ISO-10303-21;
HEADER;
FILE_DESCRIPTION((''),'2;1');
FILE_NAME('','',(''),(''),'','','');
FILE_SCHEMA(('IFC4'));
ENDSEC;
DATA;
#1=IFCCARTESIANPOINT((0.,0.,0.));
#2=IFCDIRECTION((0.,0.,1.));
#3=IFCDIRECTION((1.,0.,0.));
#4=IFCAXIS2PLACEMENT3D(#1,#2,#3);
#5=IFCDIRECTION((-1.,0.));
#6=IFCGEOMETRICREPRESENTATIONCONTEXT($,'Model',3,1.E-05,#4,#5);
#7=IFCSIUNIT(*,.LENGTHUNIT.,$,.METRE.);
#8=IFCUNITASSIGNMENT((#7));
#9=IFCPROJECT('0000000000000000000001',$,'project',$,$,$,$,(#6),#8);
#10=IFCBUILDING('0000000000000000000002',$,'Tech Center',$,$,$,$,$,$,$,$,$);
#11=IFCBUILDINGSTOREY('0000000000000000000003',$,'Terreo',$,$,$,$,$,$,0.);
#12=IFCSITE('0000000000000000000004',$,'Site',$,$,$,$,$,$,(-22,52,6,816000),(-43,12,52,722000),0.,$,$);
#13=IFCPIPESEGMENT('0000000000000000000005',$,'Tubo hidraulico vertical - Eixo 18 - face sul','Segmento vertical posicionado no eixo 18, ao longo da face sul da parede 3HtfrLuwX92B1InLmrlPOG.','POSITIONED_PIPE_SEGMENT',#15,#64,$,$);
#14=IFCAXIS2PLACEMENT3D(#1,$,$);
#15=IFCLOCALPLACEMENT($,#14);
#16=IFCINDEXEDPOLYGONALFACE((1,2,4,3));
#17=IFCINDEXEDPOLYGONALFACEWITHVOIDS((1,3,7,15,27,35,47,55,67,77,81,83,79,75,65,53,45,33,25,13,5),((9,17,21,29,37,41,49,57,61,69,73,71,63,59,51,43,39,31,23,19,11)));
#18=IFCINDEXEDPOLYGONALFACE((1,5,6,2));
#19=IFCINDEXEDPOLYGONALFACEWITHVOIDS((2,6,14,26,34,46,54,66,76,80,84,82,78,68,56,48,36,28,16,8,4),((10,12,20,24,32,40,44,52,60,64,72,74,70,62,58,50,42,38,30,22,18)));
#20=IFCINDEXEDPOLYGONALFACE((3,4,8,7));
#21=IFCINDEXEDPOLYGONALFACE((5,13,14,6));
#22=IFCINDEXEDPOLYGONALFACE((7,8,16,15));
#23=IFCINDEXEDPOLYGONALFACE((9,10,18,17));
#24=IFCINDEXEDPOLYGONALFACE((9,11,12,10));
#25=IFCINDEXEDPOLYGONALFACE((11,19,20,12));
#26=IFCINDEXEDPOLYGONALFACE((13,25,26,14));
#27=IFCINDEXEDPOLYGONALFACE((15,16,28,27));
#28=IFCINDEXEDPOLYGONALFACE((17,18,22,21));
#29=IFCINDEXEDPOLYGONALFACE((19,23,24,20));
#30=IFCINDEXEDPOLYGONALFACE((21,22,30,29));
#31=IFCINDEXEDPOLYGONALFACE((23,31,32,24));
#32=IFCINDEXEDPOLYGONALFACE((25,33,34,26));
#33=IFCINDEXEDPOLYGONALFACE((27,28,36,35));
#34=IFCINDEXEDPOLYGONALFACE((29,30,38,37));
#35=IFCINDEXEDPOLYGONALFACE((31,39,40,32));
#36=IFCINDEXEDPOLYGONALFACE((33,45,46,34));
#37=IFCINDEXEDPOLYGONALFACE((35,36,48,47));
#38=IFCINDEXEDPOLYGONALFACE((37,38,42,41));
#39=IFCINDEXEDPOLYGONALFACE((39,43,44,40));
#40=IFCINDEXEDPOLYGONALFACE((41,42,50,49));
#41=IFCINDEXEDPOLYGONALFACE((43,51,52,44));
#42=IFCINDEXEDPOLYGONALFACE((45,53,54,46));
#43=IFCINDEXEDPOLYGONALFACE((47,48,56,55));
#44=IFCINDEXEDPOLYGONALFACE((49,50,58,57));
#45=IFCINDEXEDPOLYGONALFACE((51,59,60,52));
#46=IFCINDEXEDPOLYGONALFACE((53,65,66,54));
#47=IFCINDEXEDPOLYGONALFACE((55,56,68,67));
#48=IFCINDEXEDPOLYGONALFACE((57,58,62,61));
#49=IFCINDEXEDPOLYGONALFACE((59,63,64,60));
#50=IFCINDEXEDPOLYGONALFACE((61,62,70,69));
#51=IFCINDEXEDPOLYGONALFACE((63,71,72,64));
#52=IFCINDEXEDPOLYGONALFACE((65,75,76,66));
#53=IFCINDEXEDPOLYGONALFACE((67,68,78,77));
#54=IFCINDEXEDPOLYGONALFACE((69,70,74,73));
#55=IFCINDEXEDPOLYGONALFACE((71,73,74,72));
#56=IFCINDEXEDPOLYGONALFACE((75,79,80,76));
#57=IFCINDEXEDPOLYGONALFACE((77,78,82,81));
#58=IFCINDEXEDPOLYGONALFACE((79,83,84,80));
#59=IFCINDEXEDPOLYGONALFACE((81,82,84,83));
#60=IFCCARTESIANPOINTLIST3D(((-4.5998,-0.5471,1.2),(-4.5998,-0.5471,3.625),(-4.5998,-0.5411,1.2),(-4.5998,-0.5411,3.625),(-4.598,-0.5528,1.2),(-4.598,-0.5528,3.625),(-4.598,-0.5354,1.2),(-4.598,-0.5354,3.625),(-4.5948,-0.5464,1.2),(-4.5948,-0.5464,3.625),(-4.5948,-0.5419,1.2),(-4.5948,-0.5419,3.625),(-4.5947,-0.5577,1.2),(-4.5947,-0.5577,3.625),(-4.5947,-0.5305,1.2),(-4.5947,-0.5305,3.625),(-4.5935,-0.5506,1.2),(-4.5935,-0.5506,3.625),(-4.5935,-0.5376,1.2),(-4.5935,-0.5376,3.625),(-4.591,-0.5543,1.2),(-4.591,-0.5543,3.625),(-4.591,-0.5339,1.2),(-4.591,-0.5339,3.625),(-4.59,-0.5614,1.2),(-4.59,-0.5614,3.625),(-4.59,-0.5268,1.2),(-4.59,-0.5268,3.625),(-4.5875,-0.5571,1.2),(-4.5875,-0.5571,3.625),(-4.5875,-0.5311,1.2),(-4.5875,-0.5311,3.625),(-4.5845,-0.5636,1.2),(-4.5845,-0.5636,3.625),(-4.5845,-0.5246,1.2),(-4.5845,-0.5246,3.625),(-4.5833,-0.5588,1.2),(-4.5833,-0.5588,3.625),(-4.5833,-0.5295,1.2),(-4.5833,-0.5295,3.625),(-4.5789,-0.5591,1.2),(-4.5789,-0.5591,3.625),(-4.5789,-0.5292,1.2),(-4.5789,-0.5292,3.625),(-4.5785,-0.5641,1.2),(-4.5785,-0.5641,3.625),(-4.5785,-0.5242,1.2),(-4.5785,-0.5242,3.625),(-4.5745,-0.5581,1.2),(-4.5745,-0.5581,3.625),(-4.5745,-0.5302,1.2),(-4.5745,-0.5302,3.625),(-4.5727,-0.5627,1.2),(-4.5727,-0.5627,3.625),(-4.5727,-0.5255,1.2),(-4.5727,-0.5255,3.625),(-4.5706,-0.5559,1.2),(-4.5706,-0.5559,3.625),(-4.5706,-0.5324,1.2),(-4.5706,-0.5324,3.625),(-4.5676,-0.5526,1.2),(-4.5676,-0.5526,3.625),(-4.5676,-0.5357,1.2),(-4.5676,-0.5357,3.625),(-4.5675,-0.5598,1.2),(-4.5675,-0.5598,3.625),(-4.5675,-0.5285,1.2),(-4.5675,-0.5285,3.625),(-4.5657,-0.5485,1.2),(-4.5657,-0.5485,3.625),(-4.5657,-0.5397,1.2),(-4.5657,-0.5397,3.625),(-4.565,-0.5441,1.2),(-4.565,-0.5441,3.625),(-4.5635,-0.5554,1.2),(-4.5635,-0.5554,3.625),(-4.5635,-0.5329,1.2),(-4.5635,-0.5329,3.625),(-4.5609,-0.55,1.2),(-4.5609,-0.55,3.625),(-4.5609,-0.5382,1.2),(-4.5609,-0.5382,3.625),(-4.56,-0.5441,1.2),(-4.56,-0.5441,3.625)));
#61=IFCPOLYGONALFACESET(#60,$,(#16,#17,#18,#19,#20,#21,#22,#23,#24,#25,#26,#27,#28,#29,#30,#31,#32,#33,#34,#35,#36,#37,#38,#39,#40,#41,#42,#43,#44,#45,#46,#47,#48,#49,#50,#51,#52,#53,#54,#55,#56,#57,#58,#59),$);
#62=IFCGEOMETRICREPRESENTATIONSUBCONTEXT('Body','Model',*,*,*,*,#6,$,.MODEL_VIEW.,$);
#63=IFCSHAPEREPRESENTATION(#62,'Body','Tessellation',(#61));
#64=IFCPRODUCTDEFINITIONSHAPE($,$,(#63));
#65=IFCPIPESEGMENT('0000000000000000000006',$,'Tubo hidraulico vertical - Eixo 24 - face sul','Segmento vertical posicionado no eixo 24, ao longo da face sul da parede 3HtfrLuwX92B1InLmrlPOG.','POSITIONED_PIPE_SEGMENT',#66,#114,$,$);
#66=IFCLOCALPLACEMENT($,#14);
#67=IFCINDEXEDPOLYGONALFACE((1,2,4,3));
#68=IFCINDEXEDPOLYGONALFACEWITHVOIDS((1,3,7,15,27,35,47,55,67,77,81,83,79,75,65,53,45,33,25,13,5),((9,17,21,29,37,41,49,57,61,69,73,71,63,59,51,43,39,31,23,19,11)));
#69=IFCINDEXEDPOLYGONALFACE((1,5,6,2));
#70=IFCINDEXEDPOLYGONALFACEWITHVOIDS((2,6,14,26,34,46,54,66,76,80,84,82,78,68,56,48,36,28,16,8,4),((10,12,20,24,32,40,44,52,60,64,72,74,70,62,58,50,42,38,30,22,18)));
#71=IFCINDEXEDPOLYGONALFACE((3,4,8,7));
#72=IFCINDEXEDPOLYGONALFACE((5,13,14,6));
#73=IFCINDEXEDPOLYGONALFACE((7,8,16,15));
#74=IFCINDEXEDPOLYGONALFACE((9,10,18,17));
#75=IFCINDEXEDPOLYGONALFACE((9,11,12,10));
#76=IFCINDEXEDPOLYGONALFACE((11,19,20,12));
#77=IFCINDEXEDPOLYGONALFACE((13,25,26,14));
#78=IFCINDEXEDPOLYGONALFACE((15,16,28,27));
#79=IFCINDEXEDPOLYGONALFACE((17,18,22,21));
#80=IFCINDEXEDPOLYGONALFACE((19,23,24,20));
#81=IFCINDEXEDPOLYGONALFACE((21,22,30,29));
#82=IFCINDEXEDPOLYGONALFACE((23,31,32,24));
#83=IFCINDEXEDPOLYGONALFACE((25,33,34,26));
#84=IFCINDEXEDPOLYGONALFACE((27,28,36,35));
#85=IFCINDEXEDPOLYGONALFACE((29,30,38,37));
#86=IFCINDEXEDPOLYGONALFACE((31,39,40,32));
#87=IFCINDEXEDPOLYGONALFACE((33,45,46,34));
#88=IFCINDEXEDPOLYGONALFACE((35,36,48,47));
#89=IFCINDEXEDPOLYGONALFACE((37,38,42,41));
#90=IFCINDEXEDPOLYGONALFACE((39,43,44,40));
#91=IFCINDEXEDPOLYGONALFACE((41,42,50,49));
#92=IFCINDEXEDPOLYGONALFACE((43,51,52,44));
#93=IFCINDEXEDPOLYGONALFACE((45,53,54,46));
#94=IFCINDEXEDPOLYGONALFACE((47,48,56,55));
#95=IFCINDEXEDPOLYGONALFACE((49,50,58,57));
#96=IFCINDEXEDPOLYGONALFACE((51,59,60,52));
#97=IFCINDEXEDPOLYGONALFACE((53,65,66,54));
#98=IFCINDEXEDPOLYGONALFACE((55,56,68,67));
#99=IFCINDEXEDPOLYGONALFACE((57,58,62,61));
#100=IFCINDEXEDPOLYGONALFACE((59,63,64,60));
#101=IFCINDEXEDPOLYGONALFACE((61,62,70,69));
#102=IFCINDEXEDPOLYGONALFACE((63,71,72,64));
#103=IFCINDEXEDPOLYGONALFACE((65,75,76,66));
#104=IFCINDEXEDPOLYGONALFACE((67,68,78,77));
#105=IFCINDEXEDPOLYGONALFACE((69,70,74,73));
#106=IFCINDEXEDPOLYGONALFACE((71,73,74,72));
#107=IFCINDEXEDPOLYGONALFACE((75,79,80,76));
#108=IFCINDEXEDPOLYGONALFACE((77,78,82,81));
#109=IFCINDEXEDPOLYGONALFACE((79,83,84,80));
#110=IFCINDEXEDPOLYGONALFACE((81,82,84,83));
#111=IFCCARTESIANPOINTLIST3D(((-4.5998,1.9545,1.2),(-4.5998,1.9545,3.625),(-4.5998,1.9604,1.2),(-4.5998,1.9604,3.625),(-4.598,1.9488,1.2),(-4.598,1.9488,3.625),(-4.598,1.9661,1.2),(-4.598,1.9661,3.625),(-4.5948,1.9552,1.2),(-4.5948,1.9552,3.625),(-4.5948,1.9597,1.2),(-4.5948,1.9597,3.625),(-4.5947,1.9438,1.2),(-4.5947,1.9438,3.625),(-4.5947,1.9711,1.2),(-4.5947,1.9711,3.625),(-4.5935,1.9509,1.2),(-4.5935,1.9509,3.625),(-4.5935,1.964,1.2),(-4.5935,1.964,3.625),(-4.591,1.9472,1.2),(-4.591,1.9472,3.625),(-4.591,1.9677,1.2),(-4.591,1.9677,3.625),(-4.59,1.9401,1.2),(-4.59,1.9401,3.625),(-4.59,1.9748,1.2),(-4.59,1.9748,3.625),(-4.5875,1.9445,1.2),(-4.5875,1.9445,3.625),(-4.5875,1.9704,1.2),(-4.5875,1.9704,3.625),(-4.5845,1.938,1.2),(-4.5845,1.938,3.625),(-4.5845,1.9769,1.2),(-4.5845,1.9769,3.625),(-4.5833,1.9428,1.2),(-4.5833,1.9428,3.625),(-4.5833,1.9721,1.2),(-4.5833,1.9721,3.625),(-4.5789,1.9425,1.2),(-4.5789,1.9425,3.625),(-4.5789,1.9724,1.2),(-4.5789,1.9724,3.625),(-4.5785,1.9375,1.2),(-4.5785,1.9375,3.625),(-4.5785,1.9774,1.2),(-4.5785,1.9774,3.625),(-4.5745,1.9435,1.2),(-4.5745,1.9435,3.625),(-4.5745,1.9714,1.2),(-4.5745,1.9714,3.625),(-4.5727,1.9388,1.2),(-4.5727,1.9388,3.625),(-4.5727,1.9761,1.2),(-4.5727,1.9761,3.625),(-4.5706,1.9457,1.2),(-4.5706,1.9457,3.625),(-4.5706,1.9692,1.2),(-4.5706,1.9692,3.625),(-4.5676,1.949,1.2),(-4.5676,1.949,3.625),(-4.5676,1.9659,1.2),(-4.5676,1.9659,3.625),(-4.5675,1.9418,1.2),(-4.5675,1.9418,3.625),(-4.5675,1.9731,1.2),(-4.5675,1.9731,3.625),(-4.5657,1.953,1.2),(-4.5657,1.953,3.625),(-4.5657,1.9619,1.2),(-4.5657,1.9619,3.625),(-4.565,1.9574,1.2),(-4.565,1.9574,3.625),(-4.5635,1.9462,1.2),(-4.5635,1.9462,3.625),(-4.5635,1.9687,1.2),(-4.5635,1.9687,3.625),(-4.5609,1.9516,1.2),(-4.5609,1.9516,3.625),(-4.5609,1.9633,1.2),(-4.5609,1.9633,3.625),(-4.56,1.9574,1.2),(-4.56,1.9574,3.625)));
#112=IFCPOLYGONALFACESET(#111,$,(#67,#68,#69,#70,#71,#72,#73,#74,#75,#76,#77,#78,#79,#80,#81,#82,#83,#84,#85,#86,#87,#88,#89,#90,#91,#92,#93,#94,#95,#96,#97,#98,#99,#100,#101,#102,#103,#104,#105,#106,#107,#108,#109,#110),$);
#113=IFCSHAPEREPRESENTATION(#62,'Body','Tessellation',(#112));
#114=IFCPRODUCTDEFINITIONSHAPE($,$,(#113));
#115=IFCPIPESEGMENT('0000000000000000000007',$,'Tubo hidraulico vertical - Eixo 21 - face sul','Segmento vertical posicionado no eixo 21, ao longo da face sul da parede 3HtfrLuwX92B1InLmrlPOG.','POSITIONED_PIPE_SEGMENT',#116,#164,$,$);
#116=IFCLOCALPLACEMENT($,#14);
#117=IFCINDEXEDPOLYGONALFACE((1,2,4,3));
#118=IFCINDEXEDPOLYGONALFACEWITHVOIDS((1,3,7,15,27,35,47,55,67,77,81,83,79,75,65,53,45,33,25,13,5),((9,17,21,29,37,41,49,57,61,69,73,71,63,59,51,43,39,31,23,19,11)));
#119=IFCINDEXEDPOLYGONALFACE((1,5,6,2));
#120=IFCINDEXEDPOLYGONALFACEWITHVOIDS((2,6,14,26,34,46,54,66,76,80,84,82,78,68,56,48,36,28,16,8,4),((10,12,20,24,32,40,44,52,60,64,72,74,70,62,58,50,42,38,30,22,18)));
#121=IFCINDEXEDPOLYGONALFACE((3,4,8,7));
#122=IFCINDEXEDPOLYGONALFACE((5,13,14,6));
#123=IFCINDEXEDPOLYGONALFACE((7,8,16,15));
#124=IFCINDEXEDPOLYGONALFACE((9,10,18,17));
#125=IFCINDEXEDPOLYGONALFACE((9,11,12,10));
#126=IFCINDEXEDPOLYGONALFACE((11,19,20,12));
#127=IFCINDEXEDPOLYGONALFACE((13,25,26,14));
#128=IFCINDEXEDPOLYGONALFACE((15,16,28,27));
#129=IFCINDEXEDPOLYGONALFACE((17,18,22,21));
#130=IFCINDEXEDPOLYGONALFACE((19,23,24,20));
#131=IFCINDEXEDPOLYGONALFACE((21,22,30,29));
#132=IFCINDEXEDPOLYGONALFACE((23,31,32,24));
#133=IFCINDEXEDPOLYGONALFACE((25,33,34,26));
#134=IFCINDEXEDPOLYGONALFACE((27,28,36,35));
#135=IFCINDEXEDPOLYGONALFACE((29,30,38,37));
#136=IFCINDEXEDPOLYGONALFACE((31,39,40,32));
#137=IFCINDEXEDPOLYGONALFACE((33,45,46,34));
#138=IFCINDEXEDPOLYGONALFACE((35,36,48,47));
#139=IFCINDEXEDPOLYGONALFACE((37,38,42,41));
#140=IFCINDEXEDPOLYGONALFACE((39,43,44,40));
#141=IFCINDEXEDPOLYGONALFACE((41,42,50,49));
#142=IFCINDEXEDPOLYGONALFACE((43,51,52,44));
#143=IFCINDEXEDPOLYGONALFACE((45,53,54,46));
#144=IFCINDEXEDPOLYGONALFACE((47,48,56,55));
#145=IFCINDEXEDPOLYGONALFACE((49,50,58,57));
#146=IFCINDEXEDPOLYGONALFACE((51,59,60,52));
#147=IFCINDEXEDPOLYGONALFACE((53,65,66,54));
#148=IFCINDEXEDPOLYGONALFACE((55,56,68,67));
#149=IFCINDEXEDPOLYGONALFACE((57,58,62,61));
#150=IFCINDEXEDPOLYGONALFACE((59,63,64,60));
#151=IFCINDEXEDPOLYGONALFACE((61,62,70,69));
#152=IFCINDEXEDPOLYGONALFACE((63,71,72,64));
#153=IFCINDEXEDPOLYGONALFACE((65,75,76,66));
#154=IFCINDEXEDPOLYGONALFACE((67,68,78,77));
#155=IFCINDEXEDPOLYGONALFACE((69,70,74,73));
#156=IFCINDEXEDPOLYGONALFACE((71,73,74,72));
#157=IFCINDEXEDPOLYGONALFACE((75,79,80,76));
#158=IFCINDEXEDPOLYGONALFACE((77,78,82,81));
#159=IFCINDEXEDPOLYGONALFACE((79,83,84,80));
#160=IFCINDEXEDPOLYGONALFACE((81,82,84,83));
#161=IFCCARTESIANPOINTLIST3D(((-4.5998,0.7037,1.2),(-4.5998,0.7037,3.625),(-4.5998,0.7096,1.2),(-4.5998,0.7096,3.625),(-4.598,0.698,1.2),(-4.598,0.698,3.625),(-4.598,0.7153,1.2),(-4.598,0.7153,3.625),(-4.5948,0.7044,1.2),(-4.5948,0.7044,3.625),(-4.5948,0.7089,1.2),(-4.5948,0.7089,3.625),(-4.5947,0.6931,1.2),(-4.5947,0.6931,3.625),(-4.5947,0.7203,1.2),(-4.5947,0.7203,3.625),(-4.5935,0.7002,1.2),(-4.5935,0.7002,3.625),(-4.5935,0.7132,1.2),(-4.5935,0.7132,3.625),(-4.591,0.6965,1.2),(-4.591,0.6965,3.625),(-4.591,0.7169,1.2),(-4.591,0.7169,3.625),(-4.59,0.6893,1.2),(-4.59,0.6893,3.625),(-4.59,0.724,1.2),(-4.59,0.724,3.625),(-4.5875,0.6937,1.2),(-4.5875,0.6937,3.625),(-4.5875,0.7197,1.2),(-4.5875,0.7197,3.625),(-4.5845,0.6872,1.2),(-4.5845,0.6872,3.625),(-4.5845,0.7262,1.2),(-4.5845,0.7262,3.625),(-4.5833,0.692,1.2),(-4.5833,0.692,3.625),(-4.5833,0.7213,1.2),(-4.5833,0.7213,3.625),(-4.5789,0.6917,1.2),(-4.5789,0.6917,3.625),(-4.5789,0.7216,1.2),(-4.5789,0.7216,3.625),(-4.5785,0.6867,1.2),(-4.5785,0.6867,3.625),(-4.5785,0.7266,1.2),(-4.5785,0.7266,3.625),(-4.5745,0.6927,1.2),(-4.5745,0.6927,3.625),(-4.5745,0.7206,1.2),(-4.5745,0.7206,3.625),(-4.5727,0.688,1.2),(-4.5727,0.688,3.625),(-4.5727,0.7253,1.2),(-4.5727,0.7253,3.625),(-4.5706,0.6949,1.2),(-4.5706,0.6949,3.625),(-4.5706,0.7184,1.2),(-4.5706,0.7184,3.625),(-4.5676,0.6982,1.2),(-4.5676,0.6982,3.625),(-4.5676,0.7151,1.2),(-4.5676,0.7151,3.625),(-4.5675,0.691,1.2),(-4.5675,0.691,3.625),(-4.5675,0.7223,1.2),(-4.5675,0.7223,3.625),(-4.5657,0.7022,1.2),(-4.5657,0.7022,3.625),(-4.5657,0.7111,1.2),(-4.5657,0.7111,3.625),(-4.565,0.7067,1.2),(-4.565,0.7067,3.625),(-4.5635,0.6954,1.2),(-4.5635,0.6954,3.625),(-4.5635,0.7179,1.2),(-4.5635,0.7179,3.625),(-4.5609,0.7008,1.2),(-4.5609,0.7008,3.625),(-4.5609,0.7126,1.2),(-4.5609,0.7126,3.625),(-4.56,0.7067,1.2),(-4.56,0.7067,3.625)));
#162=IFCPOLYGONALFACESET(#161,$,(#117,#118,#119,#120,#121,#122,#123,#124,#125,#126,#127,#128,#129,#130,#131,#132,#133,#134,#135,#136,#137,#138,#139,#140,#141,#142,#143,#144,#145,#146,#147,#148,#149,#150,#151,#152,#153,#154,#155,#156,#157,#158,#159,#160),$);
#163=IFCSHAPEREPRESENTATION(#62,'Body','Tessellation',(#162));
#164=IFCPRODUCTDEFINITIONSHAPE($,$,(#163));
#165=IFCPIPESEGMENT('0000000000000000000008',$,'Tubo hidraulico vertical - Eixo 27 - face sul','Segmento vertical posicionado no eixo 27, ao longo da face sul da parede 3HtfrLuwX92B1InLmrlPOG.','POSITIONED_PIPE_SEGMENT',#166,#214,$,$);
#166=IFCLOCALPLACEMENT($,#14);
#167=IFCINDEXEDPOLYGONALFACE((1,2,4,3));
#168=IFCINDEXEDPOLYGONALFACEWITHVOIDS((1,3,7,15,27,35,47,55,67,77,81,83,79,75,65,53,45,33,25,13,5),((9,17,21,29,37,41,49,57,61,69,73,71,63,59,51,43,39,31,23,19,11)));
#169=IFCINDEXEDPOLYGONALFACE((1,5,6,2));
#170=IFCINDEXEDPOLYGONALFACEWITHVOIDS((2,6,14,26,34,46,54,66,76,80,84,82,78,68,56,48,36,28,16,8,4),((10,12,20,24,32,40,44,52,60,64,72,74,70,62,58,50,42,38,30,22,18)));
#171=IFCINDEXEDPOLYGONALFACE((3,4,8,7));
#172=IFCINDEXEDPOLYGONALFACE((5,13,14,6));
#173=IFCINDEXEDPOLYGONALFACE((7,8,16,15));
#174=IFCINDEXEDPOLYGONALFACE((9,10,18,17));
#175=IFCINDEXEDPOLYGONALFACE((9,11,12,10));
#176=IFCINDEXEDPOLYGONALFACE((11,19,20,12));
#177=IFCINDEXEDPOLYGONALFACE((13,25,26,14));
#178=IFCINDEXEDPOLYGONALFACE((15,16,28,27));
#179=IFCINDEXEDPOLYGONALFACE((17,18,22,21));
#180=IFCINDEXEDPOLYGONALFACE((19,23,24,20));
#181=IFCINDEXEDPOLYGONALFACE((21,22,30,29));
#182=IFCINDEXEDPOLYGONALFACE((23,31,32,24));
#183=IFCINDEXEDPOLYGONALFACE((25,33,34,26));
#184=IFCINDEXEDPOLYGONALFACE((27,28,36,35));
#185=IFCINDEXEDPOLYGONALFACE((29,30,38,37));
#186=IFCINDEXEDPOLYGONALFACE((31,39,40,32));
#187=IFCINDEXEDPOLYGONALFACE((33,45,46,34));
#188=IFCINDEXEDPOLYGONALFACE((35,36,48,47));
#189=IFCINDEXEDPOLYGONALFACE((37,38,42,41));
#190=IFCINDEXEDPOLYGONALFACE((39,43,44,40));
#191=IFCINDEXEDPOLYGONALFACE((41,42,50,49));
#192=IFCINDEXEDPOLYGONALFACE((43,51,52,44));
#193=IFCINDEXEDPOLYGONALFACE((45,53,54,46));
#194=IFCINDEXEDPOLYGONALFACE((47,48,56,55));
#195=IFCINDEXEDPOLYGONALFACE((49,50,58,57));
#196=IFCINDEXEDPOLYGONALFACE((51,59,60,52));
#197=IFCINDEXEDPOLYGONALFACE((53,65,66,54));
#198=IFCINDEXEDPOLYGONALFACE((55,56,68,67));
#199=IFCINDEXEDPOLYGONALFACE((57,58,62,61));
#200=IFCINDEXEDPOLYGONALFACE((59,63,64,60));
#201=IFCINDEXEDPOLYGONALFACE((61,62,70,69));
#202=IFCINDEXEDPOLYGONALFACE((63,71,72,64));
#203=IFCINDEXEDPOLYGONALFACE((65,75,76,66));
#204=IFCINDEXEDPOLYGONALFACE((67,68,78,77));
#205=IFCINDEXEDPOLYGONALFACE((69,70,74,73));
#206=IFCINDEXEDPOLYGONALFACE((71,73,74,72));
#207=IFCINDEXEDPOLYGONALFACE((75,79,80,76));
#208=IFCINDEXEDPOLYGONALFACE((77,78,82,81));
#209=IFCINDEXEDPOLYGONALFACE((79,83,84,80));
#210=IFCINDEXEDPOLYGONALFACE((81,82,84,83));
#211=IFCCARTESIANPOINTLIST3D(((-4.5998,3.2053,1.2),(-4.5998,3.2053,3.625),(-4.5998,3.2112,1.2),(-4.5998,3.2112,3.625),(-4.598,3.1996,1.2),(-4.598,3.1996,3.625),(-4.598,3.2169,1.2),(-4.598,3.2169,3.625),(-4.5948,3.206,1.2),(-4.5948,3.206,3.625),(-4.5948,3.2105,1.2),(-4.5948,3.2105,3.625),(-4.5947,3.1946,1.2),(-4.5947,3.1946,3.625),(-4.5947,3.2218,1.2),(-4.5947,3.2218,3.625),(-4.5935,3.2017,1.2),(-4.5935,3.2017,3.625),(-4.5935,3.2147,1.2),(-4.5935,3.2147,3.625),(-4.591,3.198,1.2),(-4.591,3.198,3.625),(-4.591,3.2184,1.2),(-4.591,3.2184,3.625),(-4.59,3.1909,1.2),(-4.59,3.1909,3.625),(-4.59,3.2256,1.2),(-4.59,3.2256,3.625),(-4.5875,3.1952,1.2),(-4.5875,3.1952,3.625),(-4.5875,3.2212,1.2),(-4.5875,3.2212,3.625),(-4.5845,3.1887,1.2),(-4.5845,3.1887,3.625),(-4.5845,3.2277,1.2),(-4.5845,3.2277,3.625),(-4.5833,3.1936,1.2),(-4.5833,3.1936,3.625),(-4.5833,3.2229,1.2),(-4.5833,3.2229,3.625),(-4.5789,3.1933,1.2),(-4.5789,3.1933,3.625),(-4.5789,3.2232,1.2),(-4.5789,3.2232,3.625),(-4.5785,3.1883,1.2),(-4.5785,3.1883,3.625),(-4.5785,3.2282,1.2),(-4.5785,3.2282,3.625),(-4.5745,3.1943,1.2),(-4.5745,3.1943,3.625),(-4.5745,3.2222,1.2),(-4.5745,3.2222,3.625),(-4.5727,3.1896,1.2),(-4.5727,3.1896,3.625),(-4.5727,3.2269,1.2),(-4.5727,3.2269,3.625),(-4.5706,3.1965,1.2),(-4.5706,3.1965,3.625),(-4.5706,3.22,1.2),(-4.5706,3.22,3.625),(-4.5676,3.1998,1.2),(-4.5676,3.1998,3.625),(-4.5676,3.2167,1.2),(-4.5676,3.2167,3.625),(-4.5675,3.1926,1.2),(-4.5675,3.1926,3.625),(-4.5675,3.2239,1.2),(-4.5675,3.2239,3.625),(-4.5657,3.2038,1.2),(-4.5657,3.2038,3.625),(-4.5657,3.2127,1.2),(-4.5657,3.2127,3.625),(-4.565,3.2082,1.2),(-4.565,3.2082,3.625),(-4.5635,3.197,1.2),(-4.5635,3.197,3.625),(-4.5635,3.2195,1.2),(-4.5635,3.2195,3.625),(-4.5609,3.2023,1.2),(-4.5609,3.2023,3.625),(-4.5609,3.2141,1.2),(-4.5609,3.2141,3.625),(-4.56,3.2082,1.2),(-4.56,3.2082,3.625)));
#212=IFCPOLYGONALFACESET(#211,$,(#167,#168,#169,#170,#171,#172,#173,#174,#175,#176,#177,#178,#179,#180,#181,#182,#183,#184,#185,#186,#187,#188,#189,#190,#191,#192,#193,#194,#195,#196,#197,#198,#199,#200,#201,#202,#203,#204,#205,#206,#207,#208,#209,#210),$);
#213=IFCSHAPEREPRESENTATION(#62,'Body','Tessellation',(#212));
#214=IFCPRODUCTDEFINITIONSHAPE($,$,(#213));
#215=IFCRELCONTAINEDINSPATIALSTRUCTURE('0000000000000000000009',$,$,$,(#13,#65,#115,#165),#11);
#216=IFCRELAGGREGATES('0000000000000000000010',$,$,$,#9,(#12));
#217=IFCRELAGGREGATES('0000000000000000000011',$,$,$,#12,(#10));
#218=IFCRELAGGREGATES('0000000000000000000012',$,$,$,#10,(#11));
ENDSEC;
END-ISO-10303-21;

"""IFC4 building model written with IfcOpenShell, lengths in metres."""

from ifc_helpers import new_model, si_unit, direction, frame, origin_with_axes, place, context, subcontext, project, spatial, hollow_circle, extrude, element, save


model = new_model("IFC4")

# Units and contexts
model_context = context("Model", 3, precision=1e-05, world=origin_with_axes(), true_north=direction((-1.0, 0.0)))
body_context = subcontext(model_context, "Body", "Model", "MODEL_VIEW")
ifc_project = project(units=[si_unit("LENGTHUNIT", "METRE")], contexts=[model_context])

# Site, building, storey
site = spatial("IfcSite", under=ifc_project, Name="Site", RefLatitude=(-22, 52, 6, 816000), RefLongitude=(-43, 12, 52, 722000), RefElevation=0.0)
building = spatial("IfcBuilding", under=site, Name="Tech Center")
storey = spatial("IfcBuildingStorey", under=building, Name="Terreo", Elevation=0.0)

# Pipe segments
for number, where, name, description in (
    (1, (-4.58, -0.5441, 1.2), "Tubo hidraulico vertical - Eixo 18 - face sul", "Segmento vertical posicionado no eixo 18, ao longo da face sul da parede 3HtfrLuwX92B1InLmrlPOG."),
    (2, (-4.58, 1.9574, 1.2), "Tubo hidraulico vertical - Eixo 24 - face sul", "Segmento vertical posicionado no eixo 24, ao longo da face sul da parede 3HtfrLuwX92B1InLmrlPOG."),
    (3, (-4.58, 0.7067, 1.2), "Tubo hidraulico vertical - Eixo 21 - face sul", "Segmento vertical posicionado no eixo 21, ao longo da face sul da parede 3HtfrLuwX92B1InLmrlPOG."),
    (4, (-4.58, 3.2082, 1.2), "Tubo hidraulico vertical - Eixo 27 - face sul", "Segmento vertical posicionado no eixo 27, ao longo da face sul da parede 3HtfrLuwX92B1InLmrlPOG."),
):
    element("IfcPipeSegment", number, at=place(None, frame(where)), inside=storey, Name=name, Description=description, ObjectType="POSITIONED_PIPE_SEGMENT", context=body_context, shape_type="SweptSolid", body=[
        extrude(hollow_circle(Radius=0.02, WallThickness=0.005), origin_with_axes(), (0.0, 0.0, 1.0), 2.425),
    ])

save(model, "model.ifc")
